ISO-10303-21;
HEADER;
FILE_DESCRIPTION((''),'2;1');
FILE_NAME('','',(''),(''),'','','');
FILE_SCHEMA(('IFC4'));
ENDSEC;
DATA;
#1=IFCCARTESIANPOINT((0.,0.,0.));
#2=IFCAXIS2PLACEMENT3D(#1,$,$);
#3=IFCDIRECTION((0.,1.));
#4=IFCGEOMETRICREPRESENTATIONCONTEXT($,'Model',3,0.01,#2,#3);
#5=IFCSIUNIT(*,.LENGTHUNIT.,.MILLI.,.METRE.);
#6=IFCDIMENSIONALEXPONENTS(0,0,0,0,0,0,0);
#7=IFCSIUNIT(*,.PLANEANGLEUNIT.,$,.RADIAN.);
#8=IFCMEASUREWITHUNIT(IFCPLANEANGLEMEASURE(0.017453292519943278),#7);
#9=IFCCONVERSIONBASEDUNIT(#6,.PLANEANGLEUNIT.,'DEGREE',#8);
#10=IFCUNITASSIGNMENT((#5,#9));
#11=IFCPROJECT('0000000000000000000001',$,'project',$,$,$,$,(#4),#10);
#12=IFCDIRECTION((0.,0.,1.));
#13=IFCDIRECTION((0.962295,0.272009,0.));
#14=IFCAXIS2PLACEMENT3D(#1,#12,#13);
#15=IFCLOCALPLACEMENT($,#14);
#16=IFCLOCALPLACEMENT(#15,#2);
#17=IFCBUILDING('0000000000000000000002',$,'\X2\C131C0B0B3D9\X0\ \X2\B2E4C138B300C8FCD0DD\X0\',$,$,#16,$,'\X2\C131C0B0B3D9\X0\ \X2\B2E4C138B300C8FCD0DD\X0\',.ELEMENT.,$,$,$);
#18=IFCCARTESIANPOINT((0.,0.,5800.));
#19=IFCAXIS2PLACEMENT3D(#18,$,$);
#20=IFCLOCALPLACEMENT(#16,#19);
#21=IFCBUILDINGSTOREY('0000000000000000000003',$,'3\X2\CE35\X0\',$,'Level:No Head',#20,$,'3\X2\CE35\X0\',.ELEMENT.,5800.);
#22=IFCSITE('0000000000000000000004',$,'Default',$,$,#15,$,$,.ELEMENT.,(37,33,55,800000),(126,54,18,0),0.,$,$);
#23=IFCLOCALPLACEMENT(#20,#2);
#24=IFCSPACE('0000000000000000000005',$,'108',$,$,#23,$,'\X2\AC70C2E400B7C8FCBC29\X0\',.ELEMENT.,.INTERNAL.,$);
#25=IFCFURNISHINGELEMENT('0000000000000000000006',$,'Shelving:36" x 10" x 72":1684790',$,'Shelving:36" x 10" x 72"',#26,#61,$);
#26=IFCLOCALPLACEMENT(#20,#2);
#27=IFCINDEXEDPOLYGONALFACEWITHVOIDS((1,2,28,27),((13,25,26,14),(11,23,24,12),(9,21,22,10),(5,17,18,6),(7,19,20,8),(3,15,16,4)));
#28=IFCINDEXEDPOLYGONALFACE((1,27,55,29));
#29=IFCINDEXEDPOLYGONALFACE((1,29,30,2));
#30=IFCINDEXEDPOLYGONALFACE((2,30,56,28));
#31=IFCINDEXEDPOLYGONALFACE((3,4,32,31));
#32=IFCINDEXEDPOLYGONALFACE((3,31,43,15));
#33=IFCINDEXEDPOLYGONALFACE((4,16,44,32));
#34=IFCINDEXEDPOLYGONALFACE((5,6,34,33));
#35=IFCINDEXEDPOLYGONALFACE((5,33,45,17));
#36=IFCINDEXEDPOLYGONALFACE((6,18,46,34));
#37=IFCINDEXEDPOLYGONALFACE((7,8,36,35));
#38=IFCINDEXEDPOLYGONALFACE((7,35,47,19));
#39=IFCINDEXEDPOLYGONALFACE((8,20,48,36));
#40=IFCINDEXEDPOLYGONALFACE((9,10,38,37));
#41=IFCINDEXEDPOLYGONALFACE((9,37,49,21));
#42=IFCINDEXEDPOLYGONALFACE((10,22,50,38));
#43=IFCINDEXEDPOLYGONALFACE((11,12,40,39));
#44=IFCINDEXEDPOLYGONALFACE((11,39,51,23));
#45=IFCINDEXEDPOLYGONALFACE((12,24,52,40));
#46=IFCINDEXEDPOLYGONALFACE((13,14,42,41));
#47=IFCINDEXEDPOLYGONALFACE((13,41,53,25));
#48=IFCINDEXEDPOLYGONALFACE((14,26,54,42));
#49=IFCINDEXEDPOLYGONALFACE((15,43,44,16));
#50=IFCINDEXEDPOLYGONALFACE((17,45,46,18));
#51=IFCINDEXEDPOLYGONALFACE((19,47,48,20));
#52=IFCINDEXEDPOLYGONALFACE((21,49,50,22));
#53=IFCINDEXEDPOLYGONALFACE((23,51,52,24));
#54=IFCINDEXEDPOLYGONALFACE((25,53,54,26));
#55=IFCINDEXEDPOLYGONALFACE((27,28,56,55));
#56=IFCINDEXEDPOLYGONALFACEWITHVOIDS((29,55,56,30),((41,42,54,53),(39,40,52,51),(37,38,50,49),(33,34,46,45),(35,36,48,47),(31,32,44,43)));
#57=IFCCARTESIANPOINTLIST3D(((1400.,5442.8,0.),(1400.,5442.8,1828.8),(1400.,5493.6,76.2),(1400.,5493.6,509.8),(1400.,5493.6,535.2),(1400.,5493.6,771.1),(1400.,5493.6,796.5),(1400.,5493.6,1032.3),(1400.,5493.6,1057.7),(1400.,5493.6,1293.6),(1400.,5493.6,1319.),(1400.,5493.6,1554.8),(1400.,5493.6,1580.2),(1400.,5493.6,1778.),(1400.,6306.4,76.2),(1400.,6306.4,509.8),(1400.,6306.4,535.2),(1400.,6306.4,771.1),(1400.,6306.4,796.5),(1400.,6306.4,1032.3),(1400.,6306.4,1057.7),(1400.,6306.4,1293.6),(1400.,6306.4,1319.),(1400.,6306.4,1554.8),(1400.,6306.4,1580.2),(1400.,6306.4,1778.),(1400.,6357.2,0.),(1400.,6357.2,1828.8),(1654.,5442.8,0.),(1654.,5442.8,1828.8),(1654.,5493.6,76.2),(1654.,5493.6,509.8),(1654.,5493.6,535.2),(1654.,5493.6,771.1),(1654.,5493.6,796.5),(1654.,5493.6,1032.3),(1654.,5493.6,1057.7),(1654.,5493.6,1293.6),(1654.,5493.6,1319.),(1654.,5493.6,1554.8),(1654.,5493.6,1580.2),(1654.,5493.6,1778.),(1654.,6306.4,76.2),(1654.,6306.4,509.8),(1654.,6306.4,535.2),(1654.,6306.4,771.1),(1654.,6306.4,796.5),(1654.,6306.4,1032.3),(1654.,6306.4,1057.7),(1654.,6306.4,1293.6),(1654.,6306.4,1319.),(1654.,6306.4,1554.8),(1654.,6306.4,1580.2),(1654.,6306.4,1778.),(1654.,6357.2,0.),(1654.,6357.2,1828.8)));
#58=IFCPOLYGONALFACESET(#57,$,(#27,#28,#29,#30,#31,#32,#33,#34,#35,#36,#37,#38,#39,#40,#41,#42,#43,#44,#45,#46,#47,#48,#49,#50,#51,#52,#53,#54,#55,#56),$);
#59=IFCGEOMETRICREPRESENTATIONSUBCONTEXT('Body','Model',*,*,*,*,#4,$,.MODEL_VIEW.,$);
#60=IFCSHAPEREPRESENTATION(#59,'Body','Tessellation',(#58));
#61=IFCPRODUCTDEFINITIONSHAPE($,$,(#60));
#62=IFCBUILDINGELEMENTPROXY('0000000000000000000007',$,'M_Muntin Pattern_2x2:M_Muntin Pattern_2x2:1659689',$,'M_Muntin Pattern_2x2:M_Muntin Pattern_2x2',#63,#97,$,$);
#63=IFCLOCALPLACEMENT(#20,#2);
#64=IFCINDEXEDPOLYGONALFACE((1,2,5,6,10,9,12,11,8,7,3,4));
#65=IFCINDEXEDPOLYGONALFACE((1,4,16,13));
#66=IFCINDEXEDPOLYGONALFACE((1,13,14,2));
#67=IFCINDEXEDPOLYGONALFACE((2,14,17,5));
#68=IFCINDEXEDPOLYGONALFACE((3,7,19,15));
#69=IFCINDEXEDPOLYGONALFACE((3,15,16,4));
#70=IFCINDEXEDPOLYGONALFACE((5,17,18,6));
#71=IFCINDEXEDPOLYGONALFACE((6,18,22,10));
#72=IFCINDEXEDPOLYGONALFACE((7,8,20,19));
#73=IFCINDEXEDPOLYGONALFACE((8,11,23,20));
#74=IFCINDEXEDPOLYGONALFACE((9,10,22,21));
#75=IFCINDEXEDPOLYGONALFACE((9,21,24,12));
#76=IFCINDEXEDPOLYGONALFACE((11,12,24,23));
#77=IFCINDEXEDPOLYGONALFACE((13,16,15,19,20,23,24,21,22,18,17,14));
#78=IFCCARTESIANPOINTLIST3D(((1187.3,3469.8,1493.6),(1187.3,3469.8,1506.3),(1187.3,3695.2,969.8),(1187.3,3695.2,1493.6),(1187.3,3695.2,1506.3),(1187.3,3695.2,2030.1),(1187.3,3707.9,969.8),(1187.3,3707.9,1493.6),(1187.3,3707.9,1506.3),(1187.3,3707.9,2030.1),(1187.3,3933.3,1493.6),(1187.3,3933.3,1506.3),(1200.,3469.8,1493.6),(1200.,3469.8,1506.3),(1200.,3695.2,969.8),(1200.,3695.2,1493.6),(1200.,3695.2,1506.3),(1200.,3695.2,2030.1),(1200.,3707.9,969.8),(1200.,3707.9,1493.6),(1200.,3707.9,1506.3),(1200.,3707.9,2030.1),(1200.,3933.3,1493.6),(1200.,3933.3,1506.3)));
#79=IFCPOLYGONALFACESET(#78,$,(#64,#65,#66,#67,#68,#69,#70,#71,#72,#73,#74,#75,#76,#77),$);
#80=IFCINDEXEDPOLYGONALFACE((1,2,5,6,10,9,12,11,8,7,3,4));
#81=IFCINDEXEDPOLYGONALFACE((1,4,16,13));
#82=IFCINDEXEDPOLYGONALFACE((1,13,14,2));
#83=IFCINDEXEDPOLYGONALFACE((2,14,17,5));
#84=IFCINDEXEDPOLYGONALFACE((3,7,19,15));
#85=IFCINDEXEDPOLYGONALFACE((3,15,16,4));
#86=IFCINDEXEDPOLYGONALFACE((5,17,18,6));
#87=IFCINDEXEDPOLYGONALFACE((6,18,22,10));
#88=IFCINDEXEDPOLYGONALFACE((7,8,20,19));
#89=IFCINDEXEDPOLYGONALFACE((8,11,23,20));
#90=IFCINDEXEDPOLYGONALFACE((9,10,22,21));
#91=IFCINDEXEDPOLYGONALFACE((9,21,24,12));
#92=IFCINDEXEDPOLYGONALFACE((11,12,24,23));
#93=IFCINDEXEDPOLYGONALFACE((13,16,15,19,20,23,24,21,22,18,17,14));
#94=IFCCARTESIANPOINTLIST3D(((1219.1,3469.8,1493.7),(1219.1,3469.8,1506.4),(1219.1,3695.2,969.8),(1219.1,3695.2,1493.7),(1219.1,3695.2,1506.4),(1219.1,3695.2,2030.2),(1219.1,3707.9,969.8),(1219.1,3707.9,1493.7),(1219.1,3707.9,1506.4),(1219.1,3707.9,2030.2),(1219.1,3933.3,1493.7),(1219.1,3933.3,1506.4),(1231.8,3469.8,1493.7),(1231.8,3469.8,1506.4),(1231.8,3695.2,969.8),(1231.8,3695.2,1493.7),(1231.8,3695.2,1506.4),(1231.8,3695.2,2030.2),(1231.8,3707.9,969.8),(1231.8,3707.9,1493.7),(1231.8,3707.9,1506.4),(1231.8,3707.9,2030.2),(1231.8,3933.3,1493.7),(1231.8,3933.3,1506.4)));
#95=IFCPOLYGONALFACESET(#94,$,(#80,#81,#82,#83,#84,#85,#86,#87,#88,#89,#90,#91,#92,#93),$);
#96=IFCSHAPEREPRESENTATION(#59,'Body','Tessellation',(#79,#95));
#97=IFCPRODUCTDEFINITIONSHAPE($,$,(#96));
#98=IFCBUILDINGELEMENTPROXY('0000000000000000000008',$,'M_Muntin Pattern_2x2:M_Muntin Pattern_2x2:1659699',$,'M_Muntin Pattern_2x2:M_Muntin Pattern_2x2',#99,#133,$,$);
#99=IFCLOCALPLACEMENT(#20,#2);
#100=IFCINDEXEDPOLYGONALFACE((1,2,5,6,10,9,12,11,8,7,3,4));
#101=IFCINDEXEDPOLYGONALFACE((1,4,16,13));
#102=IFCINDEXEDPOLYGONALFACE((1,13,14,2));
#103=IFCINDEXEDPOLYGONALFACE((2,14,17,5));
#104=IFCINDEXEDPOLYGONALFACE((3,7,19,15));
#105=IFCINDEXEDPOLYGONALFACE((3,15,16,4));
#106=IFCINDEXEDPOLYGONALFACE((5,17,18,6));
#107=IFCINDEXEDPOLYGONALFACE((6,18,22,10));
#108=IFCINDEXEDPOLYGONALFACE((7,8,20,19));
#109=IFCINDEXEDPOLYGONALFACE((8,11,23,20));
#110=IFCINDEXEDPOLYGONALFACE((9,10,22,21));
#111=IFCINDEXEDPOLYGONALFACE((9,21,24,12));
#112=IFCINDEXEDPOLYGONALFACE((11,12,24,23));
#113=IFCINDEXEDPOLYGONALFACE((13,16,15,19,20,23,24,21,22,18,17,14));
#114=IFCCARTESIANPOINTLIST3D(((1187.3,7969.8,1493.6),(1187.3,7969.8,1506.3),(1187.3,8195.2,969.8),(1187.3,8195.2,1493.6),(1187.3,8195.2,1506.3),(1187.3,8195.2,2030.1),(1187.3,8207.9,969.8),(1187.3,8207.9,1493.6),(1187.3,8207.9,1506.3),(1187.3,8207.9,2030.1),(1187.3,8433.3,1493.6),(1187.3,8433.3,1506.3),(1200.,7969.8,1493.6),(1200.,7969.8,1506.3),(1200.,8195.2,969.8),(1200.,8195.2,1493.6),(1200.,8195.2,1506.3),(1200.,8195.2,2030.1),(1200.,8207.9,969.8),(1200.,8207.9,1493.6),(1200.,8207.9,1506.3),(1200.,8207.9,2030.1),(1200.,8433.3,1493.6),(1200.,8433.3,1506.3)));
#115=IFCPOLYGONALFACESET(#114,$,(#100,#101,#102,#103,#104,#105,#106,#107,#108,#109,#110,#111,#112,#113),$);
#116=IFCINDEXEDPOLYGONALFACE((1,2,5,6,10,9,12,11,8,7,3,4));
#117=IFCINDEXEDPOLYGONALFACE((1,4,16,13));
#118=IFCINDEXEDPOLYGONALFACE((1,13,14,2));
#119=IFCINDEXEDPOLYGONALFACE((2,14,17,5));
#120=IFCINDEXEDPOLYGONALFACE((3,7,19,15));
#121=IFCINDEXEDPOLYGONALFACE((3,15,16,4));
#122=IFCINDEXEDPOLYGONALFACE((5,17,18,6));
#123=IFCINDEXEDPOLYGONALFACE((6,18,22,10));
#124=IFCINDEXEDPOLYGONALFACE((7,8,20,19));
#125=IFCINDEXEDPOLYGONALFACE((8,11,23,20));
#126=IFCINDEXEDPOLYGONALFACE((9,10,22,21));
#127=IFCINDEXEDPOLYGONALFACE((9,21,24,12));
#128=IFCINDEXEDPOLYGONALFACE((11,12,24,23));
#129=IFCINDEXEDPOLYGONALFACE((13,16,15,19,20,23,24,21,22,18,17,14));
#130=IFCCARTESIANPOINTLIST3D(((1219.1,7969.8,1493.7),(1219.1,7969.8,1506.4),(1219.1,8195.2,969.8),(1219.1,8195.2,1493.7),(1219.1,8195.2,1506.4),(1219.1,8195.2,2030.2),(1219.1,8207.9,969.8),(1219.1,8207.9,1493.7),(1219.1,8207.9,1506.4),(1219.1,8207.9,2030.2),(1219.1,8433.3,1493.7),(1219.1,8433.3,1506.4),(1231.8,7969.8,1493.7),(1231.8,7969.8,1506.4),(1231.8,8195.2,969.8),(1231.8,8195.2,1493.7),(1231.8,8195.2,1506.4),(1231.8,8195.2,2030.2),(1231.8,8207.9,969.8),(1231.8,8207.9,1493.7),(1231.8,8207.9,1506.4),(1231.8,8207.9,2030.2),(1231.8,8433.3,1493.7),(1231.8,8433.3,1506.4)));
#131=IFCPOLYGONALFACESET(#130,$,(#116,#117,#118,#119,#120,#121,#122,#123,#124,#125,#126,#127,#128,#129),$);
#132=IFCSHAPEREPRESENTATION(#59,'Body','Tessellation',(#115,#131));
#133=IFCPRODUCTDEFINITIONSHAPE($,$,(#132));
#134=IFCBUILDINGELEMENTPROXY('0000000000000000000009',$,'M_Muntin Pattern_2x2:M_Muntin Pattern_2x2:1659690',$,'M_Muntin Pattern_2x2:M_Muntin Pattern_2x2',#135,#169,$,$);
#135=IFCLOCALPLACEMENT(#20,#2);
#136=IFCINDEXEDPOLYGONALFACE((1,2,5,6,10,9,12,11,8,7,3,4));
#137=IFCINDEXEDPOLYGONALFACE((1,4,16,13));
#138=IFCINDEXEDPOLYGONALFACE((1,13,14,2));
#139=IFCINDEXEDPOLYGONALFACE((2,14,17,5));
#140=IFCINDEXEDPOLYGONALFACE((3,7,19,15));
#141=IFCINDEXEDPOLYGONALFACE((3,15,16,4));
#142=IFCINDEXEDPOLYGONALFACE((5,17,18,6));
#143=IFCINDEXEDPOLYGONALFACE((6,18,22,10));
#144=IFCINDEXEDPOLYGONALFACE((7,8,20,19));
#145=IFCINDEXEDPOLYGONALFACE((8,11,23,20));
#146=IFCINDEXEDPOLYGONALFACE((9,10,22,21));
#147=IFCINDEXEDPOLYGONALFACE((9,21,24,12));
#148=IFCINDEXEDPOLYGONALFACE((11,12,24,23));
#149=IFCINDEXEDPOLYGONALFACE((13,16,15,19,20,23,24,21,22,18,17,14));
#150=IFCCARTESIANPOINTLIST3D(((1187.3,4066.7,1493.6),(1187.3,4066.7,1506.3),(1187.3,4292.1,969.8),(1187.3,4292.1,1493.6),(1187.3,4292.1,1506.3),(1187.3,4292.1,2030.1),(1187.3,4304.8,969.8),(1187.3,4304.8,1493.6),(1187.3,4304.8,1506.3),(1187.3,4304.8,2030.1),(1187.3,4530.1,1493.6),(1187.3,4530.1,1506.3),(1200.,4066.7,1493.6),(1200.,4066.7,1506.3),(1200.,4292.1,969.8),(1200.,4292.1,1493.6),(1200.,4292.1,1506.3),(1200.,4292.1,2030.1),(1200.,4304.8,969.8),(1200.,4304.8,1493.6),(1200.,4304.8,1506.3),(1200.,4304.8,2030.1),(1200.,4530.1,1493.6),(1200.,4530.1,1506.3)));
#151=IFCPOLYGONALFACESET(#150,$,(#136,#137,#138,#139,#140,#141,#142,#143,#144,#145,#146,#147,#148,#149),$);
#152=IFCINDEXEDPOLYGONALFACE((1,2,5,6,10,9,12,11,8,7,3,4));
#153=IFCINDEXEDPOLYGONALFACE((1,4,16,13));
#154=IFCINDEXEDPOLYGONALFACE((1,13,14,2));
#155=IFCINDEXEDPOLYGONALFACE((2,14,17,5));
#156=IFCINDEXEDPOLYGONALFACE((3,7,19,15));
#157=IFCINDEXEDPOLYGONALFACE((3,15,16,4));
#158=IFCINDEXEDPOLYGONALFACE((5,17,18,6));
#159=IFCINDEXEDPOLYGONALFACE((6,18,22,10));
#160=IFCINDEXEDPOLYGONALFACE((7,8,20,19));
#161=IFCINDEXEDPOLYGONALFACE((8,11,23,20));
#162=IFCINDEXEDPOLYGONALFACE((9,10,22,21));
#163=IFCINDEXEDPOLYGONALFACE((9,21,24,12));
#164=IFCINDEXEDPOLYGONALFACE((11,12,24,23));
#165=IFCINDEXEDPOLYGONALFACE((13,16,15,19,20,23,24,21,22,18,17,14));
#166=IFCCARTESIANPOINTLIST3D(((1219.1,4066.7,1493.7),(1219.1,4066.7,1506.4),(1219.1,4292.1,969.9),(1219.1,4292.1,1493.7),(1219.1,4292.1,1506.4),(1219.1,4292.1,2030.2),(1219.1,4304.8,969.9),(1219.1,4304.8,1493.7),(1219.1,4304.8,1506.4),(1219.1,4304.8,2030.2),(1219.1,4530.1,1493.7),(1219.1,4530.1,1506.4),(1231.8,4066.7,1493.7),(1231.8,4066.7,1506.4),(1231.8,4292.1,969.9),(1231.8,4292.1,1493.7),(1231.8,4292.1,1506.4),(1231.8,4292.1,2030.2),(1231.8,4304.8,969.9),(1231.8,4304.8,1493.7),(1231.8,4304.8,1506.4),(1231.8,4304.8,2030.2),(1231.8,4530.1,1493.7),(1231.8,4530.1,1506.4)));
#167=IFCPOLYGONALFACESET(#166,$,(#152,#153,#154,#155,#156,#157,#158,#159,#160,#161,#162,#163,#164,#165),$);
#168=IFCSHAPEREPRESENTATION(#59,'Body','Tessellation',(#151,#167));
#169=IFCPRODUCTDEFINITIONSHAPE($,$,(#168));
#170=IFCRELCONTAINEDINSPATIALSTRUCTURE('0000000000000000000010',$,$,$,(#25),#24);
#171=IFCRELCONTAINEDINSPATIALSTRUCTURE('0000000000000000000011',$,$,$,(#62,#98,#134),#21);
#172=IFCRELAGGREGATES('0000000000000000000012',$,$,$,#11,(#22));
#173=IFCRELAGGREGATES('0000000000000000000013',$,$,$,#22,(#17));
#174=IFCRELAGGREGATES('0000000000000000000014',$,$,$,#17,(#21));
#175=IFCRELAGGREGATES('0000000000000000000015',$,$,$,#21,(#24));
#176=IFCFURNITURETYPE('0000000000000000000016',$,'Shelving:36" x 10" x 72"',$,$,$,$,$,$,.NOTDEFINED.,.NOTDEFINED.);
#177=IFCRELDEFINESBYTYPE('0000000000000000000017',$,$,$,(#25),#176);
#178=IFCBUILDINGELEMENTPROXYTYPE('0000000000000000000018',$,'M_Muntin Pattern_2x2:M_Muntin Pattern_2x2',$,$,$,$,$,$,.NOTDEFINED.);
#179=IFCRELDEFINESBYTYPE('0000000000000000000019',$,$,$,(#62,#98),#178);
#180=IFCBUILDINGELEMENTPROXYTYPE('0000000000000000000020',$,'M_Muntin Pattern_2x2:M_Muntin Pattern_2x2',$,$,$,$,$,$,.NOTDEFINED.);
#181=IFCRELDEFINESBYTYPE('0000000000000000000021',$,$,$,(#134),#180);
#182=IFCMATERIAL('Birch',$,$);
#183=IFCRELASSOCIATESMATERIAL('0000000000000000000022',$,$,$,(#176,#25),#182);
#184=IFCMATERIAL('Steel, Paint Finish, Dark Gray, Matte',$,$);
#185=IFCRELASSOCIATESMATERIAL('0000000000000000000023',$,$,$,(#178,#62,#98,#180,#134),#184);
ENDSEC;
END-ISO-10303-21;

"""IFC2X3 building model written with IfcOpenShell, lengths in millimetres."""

from ifc_helpers import new_model, entity, si_unit, converted_unit, direction, frame, origin, place, context, subcontext, project, spatial, polyline, outline, extrude, source, transform, mapped, material, type_object, type_shapes, element, save


model = new_model("IFC2X3")

# Units and contexts
model_context = context("Model", 3, precision=0.01, world=origin(), true_north=direction((0.0, 1.0)))
body_context = subcontext(model_context, "Body", "Model", "MODEL_VIEW")
ifc_project = project(units=[si_unit("LENGTHUNIT", "METRE", prefix="MILLI"), converted_unit("PLANEANGLEUNIT", "DEGREE", entity("IfcPlaneAngleMeasure", 0.017453292519943278), si_unit("PLANEANGLEUNIT", "RADIAN"), dimensions=[0, 0, 0, 0, 0, 0, 0])], contexts=[model_context])

# Site, building, storey
site_placement = place(None, frame((0.0, 0.0, 0.0), z_axis=(0.0, 0.0, 1.0), x_axis=(0.962295, 0.272009, 0.0)))
site = spatial("IfcSite", under=ifc_project, at=site_placement, Name="Default", CompositionType="ELEMENT", RefLatitude=(37, 33, 55, 800000), RefLongitude=(126, 54, 18, 0), RefElevation=0.0)
building_placement = place(site_placement, origin())
building = spatial("IfcBuilding", under=site, at=building_placement, Name="성산동 다세대주택", LongName="성산동 다세대주택", CompositionType="ELEMENT")
storey_placement = place(building_placement, frame((0.0, 0.0, 5800.0)))
storey = spatial("IfcBuildingStorey", under=building, at=storey_placement, Name="3층", ObjectType="Level:No Head", LongName="3층", CompositionType="ELEMENT", Elevation=5800.0)

# Shared definitions
space_1_placement = place(storey_placement, origin())
space_1 = spatial("IfcSpace", under=storey, at=space_1_placement, Name="108", LongName="거실·주방", CompositionType="ELEMENT", InteriorOrExteriorSpace="INTERNAL")

# Furnishing element
ifc_material_1 = material(Name="Birch")
furniture_type_1 = type_object("IfcFurnitureType", Name="Shelving:36\" x 10\" x 72\"", AssemblyPlace="NOTDEFINED", material=ifc_material_1)
shared_shape_1 = source(origin(), body_context, "Body", "SweptSolid", [
    extrude(outline(polyline([(-457.2, -914.4), (457.2, -914.4), (457.2, 914.4), (-457.2, 914.4), (-457.2, -914.4)]), holes=[polyline([(-406.4, 863.6), (406.4, 863.6), (406.4, 665.8), (-406.4, 665.8), (-406.4, 863.6)]), polyline([(-406.4, -838.2), (-406.4, -404.6), (406.4, -404.6), (406.4, -838.2), (-406.4, -838.2)]), polyline([(406.4, 143.3), (-406.4, 143.3), (-406.4, 379.2), (406.4, 379.2), (406.4, 143.3)]), polyline([(-406.4, 640.4), (406.4, 640.4), (406.4, 404.6), (-406.4, 404.6), (-406.4, 640.4)]), polyline([(-406.4, 117.9), (406.4, 117.9), (406.4, -117.9), (-406.4, -117.9), (-406.4, 117.9)]), polyline([(-406.4, -143.3), (406.4, -143.3), (406.4, -379.2), (-406.4, -379.2), (-406.4, -143.3)])]), frame((0.0, -431.8, 914.4), z_axis=(0.0, 1.0, 0.0), x_axis=(-1.0, 0.0, 0.0)), (0.0, 0.0, 1.0), 254.0),
])
type_shapes(furniture_type_1, [shared_shape_1])
furnishing_1_placement = place(space_1_placement, frame((1222.2, 5900.0, 0.0), z_axis=(0.0, 0.0, 1.0), x_axis=(0.0, 1.0, 0.0)))
element("IfcFurnishingElement", 1, at=furnishing_1_placement, inside=space_1, type_object=furniture_type_1, material=ifc_material_1, Name="Shelving:36\" x 10\" x 72\":1684790", ObjectType="Shelving:36\" x 10\" x 72\"", context=body_context, shape_type="MappedRepresentation", body=[
    mapped(shared_shape_1, transform((0.0, 0.0, 0.0), scale=1.0)),
])

# Building element proxies
ifc_material_2 = material(Name="Steel, Paint Finish, Dark Gray, Matte")
building_element_proxy_type_1 = type_object("IfcBuildingElementProxyType", Name="M_Muntin Pattern_2x2:M_Muntin Pattern_2x2", PredefinedType="NOTDEFINED", material=ifc_material_2)
shared_shape_2 = source(origin(), body_context, "Body", "SweptSolid", [
    extrude(outline(polyline([(6.4, -6.4), (530.1, -6.4), (530.1, 6.3), (6.4, 6.3), (6.4, 231.7), (-6.3, 231.7), (-6.3, 6.3), (-530.2, 6.3), (-530.2, -6.4), (-6.3, -6.4), (-6.3, -231.7), (6.4, -231.7), (6.4, -6.4)])), frame((0.0, 9.5, 530.1), z_axis=(0.0, 1.0, 0.0), x_axis=(0.0, 0.0, 1.0)), (0.0, 0.0, 1.0), 12.7),
    extrude(outline(polyline([(6.4, -6.4), (530.2, -6.4), (530.2, 6.3), (6.4, 6.3), (6.4, 231.7), (-6.3, 231.7), (-6.3, 6.3), (-530.2, 6.3), (-530.2, -6.4), (-6.3, -6.4), (-6.3, -231.7), (6.4, -231.7), (6.4, -6.4)])), frame((0.0, -22.2, 530.2), z_axis=(0.0, 1.0, 0.0), x_axis=(0.0, 0.0, 1.0)), (0.0, 0.0, 1.0), 12.7),
])
type_shapes(building_element_proxy_type_1, [shared_shape_2])
for number, where, z_axis, x_axis, name in (
    (2, (1209.5, 3701.6, 969.8), (0.0, 0.0, 1.0), (0.0, 1.0, 0.0), "M_Muntin Pattern_2x2:M_Muntin Pattern_2x2:1659689"),
    (3, (1209.5, 8201.6, 969.8), (0.0, 0.0, 1.0), (0.0, 1.0, 0.0), "M_Muntin Pattern_2x2:M_Muntin Pattern_2x2:1659699"),
):
    element("IfcBuildingElementProxy", number, at=place(storey_placement, frame(where, z_axis=z_axis, x_axis=x_axis)), inside=storey, type_object=building_element_proxy_type_1, material=ifc_material_2, Name=name, ObjectType="M_Muntin Pattern_2x2:M_Muntin Pattern_2x2", context=body_context, shape_type="MappedRepresentation", body=[
        mapped(shared_shape_2, transform((0.0, 0.0, 0.0), scale=1.0)),
    ])
building_element_proxy_type_2 = type_object("IfcBuildingElementProxyType", Name="M_Muntin Pattern_2x2:M_Muntin Pattern_2x2", PredefinedType="NOTDEFINED", material=ifc_material_2)
shared_shape_3 = source(origin(), body_context, "Body", "SweptSolid", [
    extrude(outline(polyline([(6.4, -6.4), (530.1, -6.4), (530.1, 6.3), (6.4, 6.3), (6.4, 231.7), (-6.3, 231.7), (-6.3, 6.3), (-530.2, 6.3), (-530.2, -6.4), (-6.3, -6.4), (-6.3, -231.7), (6.4, -231.7), (6.4, -6.4)])), frame((0.0, -22.2, 530.1), z_axis=(0.0, 1.0, 0.0), x_axis=(0.0, 0.0, 1.0)), (0.0, 0.0, 1.0), 12.7),
    extrude(outline(polyline([(6.4, -6.4), (530.2, -6.4), (530.2, 6.3), (6.4, 6.3), (6.4, 231.7), (-6.3, 231.7), (-6.3, 6.3), (-530.2, 6.3), (-530.2, -6.4), (-6.3, -6.4), (-6.3, -231.7), (6.4, -231.7), (6.4, -6.4)])), frame((0.0, 9.5, 530.2), z_axis=(0.0, 1.0, 0.0), x_axis=(0.0, 0.0, 1.0)), (0.0, 0.0, 1.0), 12.7),
])
type_shapes(building_element_proxy_type_2, [shared_shape_3])
for number, where, z_axis, x_axis, name in (
    (4, (1209.5, 4298.4, 969.9), (0.0, 0.0, 1.0), (0.0, -1.0, 0.0), "M_Muntin Pattern_2x2:M_Muntin Pattern_2x2:1659690"),
):
    element("IfcBuildingElementProxy", number, at=place(storey_placement, frame(where, z_axis=z_axis, x_axis=x_axis)), inside=storey, type_object=building_element_proxy_type_2, material=ifc_material_2, Name=name, ObjectType="M_Muntin Pattern_2x2:M_Muntin Pattern_2x2", context=body_context, shape_type="MappedRepresentation", body=[
        mapped(shared_shape_3, transform((0.0, 0.0, 0.0), scale=1.0)),
    ])

save(model, "model.ifc")
